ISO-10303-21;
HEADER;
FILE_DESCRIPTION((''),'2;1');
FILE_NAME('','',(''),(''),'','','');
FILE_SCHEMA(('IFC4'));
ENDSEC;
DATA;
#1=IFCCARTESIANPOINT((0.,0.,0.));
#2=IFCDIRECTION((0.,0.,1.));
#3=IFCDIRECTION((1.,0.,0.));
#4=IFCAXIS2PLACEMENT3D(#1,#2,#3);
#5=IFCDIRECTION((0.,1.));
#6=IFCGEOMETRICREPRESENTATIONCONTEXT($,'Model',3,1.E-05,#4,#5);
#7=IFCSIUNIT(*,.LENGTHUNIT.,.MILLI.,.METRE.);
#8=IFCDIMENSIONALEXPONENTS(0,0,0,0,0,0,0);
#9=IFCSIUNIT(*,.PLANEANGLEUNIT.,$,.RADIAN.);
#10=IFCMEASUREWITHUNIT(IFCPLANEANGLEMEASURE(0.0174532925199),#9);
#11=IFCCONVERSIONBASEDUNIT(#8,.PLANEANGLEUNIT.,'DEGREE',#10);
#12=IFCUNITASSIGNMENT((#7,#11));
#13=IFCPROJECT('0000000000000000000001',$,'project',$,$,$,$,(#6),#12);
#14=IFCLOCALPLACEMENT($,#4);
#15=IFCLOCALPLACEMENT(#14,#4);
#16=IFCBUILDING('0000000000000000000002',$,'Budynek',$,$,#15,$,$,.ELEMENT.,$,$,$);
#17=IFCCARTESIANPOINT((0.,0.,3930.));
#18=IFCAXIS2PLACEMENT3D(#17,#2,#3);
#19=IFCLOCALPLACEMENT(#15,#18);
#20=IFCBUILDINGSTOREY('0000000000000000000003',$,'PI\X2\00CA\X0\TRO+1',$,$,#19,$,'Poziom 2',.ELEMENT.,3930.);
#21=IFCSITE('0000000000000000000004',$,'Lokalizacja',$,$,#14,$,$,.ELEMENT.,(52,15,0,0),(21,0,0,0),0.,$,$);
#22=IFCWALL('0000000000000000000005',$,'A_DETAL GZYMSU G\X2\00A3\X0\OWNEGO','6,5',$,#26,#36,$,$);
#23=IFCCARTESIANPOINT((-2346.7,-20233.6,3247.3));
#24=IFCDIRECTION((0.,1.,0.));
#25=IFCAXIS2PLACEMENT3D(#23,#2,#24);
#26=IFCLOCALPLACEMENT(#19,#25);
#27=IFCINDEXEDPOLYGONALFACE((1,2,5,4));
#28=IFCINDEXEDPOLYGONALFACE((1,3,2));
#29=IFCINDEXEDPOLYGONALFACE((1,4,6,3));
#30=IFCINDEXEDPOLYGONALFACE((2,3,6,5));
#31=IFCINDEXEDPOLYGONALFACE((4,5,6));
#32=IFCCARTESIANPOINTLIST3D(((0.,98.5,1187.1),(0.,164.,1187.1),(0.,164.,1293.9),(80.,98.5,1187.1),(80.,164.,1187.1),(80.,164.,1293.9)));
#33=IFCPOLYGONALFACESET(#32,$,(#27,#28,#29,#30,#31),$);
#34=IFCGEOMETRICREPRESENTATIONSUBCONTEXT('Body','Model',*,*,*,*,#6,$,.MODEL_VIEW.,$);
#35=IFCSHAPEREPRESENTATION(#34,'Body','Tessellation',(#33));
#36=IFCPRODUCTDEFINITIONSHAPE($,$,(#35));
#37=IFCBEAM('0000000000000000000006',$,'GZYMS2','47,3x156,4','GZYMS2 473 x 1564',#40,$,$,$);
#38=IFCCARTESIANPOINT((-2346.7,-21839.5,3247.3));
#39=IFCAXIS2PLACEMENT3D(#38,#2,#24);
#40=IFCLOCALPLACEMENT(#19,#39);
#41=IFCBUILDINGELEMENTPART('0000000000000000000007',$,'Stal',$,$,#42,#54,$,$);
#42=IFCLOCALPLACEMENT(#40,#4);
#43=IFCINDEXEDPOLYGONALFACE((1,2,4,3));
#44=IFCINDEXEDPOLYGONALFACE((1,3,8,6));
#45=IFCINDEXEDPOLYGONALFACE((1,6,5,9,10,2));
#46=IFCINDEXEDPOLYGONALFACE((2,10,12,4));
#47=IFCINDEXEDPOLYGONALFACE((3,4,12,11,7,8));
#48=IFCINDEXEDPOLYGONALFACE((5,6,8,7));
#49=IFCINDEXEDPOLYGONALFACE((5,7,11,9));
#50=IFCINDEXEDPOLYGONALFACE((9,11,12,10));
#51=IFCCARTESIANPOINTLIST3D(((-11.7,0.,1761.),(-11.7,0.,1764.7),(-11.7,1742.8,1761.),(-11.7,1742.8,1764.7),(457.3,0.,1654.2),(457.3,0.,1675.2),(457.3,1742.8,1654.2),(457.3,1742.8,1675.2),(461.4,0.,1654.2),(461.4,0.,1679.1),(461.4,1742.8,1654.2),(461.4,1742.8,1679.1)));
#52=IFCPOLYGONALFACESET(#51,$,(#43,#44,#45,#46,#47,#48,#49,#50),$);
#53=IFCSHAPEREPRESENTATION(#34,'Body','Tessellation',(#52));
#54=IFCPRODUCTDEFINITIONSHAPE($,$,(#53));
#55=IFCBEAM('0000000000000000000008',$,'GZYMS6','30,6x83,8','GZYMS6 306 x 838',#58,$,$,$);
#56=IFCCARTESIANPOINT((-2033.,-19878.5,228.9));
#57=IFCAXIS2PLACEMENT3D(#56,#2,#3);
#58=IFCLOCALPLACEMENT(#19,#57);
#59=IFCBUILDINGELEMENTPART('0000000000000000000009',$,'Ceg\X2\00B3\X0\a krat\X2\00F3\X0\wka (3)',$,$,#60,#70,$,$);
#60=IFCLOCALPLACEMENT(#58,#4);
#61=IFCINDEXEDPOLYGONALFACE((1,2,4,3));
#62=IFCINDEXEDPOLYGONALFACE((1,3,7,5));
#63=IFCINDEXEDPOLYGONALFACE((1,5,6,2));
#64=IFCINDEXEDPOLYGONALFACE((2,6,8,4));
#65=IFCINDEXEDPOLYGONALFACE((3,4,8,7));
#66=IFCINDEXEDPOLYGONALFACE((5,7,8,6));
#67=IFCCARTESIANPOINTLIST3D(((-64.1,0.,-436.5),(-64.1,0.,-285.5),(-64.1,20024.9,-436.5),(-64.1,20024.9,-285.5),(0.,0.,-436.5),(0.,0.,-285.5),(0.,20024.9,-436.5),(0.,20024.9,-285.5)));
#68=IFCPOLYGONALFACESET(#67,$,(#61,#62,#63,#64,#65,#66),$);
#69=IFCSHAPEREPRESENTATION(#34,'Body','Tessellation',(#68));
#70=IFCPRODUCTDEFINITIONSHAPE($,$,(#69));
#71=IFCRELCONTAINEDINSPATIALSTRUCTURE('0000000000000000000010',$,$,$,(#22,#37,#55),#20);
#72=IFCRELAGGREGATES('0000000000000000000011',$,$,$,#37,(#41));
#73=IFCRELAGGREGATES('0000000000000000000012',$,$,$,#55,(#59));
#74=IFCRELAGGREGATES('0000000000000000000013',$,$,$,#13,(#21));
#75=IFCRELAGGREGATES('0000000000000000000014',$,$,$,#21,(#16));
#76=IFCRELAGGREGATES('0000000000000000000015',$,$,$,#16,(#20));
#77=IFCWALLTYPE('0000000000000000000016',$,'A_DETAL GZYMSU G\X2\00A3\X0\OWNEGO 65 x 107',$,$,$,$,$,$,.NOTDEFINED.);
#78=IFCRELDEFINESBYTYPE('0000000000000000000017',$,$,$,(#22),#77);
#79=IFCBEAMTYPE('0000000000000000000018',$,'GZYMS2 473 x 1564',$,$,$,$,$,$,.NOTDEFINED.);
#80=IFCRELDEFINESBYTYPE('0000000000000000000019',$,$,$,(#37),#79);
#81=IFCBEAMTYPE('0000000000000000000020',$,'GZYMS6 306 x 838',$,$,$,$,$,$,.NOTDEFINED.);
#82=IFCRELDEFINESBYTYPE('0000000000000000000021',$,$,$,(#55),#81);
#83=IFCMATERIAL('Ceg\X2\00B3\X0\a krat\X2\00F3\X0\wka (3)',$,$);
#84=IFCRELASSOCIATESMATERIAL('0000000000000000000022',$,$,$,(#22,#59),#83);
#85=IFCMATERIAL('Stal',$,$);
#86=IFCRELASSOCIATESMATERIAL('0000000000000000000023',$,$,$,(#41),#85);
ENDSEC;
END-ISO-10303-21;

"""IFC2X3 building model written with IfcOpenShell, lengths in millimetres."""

from ifc_helpers import new_model, entity, si_unit, converted_unit, direction, frame, origin_with_axes, place, context, subcontext, project, spatial, polyline, outline, extrude, material, type_object, element, aggregate, save


model = new_model("IFC2X3")

# Units and contexts
model_context = context("Model", 3, precision=1e-05, world=origin_with_axes(), true_north=direction((0.0, 1.0)))
body_context = subcontext(model_context, "Body", "Model", "MODEL_VIEW")
ifc_project = project(units=[si_unit("LENGTHUNIT", "METRE", prefix="MILLI"), converted_unit("PLANEANGLEUNIT", "DEGREE", entity("IfcPlaneAngleMeasure", 0.0174532925199), si_unit("PLANEANGLEUNIT", "RADIAN"), dimensions=[0, 0, 0, 0, 0, 0, 0])], contexts=[model_context])

# Site, building, storey
site_placement = place(None, origin_with_axes())
site = spatial("IfcSite", under=ifc_project, at=site_placement, Name="Lokalizacja", CompositionType="ELEMENT", RefLatitude=(52, 15, 0, 0), RefLongitude=(21, 0, 0, 0), RefElevation=0.0)
building_placement = place(site_placement, origin_with_axes())
building = spatial("IfcBuilding", under=site, at=building_placement, Name="Budynek", CompositionType="ELEMENT")
storey_placement = place(building_placement, frame((0.0, 0.0, 3930.0), z_axis=(0.0, 0.0, 1.0), x_axis=(1.0, 0.0, 0.0)))
storey = spatial("IfcBuildingStorey", under=building, at=storey_placement, Name="PIÊTRO+1", LongName="Poziom 2", CompositionType="ELEMENT", Elevation=3930.0)

# Shared definitions
ifc_material_1 = material(Name="Ceg³a kratówka (3)")

# Wall
wall_type_1 = type_object("IfcWallType", Name="A_DETAL GZYMSU G£OWNEGO 65 x 107", PredefinedType="NOTDEFINED")
wall_1_placement = place(storey_placement, frame((-2346.7, -20233.6, 3247.3), z_axis=(0.0, 0.0, 1.0), x_axis=(0.0, 1.0, 0.0)))
element("IfcWall", 1, at=wall_1_placement, inside=storey, type_object=wall_type_1, material=ifc_material_1, Name="A_DETAL GZYMSU G£OWNEGO", Description="6,5", context=body_context, shape_type="SweptSolid", body=[
    extrude(outline(polyline([(-164.0, 1293.9), (-164.0, 1187.1), (-98.5, 1187.1), (-164.0, 1293.9)])), frame((0.0, 0.0, 0.0), z_axis=(-1.0, 0.0, 0.0), x_axis=(0.0, -1.0, 0.0)), (0.0, 0.0, -1.0), 80.0),
])

# Beam, building element part
beam_type_1 = type_object("IfcBeamType", Name="GZYMS2 473 x 1564", PredefinedType="NOTDEFINED")
beam_1_placement = place(storey_placement, frame((-2346.7, -21839.5, 3247.3), z_axis=(0.0, 0.0, 1.0), x_axis=(0.0, 1.0, 0.0)))
beam_1 = element("IfcBeam", 2, at=beam_1_placement, inside=storey, type_object=beam_type_1, Name="GZYMS2", Description="47,3x156,4", ObjectType="GZYMS2 473 x 1564")
ifc_material_2 = material(Name="Stal")
building_element_part_1_placement = place(beam_1_placement, origin_with_axes())
building_element_part_1 = element("IfcBuildingElementPart", 3, at=building_element_part_1_placement, material=ifc_material_2, Name="Stal", context=body_context, shape_type="SweptSolid", body=[
    extrude(outline(polyline([(11.7, 1764.7), (-461.4, 1679.1), (-461.4, 1654.2), (-457.3, 1654.2), (-457.3, 1675.2), (11.7, 1761.0), (11.7, 1764.7)])), frame((0.0, 1742.8, 0.0), z_axis=(0.0, 1.0, 0.0), x_axis=(-1.0, 0.0, 0.0)), (0.0, 0.0, -1.0), 1742.8),
])
aggregate(beam_1, [building_element_part_1])

# Beam, building element part
beam_type_2 = type_object("IfcBeamType", Name="GZYMS6 306 x 838", PredefinedType="NOTDEFINED")
beam_2_placement = place(storey_placement, frame((-2033.0, -19878.5, 228.9), z_axis=(0.0, 0.0, 1.0), x_axis=(1.0, 0.0, 0.0)))
beam_2 = element("IfcBeam", 4, at=beam_2_placement, inside=storey, type_object=beam_type_2, Name="GZYMS6", Description="30,6x83,8", ObjectType="GZYMS6 306 x 838")
building_element_part_2_placement = place(beam_2_placement, origin_with_axes())
building_element_part_2 = element("IfcBuildingElementPart", 5, at=building_element_part_2_placement, material=ifc_material_1, Name="Ceg³a kratówka (3)", context=body_context, shape_type="SweptSolid", body=[
    extrude(outline(polyline([(0.0, -285.5), (-64.1, -285.5), (-64.1, -436.5), (0.0, -436.5), (0.0, -285.5)])), frame((0.0, 20024.9, 0.0), z_axis=(0.0, -1.0, 0.0), x_axis=(1.0, 0.0, 0.0)), (0.0, 0.0, 1.0), 20024.9),
])
aggregate(beam_2, [building_element_part_2])

save(model, "model.ifc")
